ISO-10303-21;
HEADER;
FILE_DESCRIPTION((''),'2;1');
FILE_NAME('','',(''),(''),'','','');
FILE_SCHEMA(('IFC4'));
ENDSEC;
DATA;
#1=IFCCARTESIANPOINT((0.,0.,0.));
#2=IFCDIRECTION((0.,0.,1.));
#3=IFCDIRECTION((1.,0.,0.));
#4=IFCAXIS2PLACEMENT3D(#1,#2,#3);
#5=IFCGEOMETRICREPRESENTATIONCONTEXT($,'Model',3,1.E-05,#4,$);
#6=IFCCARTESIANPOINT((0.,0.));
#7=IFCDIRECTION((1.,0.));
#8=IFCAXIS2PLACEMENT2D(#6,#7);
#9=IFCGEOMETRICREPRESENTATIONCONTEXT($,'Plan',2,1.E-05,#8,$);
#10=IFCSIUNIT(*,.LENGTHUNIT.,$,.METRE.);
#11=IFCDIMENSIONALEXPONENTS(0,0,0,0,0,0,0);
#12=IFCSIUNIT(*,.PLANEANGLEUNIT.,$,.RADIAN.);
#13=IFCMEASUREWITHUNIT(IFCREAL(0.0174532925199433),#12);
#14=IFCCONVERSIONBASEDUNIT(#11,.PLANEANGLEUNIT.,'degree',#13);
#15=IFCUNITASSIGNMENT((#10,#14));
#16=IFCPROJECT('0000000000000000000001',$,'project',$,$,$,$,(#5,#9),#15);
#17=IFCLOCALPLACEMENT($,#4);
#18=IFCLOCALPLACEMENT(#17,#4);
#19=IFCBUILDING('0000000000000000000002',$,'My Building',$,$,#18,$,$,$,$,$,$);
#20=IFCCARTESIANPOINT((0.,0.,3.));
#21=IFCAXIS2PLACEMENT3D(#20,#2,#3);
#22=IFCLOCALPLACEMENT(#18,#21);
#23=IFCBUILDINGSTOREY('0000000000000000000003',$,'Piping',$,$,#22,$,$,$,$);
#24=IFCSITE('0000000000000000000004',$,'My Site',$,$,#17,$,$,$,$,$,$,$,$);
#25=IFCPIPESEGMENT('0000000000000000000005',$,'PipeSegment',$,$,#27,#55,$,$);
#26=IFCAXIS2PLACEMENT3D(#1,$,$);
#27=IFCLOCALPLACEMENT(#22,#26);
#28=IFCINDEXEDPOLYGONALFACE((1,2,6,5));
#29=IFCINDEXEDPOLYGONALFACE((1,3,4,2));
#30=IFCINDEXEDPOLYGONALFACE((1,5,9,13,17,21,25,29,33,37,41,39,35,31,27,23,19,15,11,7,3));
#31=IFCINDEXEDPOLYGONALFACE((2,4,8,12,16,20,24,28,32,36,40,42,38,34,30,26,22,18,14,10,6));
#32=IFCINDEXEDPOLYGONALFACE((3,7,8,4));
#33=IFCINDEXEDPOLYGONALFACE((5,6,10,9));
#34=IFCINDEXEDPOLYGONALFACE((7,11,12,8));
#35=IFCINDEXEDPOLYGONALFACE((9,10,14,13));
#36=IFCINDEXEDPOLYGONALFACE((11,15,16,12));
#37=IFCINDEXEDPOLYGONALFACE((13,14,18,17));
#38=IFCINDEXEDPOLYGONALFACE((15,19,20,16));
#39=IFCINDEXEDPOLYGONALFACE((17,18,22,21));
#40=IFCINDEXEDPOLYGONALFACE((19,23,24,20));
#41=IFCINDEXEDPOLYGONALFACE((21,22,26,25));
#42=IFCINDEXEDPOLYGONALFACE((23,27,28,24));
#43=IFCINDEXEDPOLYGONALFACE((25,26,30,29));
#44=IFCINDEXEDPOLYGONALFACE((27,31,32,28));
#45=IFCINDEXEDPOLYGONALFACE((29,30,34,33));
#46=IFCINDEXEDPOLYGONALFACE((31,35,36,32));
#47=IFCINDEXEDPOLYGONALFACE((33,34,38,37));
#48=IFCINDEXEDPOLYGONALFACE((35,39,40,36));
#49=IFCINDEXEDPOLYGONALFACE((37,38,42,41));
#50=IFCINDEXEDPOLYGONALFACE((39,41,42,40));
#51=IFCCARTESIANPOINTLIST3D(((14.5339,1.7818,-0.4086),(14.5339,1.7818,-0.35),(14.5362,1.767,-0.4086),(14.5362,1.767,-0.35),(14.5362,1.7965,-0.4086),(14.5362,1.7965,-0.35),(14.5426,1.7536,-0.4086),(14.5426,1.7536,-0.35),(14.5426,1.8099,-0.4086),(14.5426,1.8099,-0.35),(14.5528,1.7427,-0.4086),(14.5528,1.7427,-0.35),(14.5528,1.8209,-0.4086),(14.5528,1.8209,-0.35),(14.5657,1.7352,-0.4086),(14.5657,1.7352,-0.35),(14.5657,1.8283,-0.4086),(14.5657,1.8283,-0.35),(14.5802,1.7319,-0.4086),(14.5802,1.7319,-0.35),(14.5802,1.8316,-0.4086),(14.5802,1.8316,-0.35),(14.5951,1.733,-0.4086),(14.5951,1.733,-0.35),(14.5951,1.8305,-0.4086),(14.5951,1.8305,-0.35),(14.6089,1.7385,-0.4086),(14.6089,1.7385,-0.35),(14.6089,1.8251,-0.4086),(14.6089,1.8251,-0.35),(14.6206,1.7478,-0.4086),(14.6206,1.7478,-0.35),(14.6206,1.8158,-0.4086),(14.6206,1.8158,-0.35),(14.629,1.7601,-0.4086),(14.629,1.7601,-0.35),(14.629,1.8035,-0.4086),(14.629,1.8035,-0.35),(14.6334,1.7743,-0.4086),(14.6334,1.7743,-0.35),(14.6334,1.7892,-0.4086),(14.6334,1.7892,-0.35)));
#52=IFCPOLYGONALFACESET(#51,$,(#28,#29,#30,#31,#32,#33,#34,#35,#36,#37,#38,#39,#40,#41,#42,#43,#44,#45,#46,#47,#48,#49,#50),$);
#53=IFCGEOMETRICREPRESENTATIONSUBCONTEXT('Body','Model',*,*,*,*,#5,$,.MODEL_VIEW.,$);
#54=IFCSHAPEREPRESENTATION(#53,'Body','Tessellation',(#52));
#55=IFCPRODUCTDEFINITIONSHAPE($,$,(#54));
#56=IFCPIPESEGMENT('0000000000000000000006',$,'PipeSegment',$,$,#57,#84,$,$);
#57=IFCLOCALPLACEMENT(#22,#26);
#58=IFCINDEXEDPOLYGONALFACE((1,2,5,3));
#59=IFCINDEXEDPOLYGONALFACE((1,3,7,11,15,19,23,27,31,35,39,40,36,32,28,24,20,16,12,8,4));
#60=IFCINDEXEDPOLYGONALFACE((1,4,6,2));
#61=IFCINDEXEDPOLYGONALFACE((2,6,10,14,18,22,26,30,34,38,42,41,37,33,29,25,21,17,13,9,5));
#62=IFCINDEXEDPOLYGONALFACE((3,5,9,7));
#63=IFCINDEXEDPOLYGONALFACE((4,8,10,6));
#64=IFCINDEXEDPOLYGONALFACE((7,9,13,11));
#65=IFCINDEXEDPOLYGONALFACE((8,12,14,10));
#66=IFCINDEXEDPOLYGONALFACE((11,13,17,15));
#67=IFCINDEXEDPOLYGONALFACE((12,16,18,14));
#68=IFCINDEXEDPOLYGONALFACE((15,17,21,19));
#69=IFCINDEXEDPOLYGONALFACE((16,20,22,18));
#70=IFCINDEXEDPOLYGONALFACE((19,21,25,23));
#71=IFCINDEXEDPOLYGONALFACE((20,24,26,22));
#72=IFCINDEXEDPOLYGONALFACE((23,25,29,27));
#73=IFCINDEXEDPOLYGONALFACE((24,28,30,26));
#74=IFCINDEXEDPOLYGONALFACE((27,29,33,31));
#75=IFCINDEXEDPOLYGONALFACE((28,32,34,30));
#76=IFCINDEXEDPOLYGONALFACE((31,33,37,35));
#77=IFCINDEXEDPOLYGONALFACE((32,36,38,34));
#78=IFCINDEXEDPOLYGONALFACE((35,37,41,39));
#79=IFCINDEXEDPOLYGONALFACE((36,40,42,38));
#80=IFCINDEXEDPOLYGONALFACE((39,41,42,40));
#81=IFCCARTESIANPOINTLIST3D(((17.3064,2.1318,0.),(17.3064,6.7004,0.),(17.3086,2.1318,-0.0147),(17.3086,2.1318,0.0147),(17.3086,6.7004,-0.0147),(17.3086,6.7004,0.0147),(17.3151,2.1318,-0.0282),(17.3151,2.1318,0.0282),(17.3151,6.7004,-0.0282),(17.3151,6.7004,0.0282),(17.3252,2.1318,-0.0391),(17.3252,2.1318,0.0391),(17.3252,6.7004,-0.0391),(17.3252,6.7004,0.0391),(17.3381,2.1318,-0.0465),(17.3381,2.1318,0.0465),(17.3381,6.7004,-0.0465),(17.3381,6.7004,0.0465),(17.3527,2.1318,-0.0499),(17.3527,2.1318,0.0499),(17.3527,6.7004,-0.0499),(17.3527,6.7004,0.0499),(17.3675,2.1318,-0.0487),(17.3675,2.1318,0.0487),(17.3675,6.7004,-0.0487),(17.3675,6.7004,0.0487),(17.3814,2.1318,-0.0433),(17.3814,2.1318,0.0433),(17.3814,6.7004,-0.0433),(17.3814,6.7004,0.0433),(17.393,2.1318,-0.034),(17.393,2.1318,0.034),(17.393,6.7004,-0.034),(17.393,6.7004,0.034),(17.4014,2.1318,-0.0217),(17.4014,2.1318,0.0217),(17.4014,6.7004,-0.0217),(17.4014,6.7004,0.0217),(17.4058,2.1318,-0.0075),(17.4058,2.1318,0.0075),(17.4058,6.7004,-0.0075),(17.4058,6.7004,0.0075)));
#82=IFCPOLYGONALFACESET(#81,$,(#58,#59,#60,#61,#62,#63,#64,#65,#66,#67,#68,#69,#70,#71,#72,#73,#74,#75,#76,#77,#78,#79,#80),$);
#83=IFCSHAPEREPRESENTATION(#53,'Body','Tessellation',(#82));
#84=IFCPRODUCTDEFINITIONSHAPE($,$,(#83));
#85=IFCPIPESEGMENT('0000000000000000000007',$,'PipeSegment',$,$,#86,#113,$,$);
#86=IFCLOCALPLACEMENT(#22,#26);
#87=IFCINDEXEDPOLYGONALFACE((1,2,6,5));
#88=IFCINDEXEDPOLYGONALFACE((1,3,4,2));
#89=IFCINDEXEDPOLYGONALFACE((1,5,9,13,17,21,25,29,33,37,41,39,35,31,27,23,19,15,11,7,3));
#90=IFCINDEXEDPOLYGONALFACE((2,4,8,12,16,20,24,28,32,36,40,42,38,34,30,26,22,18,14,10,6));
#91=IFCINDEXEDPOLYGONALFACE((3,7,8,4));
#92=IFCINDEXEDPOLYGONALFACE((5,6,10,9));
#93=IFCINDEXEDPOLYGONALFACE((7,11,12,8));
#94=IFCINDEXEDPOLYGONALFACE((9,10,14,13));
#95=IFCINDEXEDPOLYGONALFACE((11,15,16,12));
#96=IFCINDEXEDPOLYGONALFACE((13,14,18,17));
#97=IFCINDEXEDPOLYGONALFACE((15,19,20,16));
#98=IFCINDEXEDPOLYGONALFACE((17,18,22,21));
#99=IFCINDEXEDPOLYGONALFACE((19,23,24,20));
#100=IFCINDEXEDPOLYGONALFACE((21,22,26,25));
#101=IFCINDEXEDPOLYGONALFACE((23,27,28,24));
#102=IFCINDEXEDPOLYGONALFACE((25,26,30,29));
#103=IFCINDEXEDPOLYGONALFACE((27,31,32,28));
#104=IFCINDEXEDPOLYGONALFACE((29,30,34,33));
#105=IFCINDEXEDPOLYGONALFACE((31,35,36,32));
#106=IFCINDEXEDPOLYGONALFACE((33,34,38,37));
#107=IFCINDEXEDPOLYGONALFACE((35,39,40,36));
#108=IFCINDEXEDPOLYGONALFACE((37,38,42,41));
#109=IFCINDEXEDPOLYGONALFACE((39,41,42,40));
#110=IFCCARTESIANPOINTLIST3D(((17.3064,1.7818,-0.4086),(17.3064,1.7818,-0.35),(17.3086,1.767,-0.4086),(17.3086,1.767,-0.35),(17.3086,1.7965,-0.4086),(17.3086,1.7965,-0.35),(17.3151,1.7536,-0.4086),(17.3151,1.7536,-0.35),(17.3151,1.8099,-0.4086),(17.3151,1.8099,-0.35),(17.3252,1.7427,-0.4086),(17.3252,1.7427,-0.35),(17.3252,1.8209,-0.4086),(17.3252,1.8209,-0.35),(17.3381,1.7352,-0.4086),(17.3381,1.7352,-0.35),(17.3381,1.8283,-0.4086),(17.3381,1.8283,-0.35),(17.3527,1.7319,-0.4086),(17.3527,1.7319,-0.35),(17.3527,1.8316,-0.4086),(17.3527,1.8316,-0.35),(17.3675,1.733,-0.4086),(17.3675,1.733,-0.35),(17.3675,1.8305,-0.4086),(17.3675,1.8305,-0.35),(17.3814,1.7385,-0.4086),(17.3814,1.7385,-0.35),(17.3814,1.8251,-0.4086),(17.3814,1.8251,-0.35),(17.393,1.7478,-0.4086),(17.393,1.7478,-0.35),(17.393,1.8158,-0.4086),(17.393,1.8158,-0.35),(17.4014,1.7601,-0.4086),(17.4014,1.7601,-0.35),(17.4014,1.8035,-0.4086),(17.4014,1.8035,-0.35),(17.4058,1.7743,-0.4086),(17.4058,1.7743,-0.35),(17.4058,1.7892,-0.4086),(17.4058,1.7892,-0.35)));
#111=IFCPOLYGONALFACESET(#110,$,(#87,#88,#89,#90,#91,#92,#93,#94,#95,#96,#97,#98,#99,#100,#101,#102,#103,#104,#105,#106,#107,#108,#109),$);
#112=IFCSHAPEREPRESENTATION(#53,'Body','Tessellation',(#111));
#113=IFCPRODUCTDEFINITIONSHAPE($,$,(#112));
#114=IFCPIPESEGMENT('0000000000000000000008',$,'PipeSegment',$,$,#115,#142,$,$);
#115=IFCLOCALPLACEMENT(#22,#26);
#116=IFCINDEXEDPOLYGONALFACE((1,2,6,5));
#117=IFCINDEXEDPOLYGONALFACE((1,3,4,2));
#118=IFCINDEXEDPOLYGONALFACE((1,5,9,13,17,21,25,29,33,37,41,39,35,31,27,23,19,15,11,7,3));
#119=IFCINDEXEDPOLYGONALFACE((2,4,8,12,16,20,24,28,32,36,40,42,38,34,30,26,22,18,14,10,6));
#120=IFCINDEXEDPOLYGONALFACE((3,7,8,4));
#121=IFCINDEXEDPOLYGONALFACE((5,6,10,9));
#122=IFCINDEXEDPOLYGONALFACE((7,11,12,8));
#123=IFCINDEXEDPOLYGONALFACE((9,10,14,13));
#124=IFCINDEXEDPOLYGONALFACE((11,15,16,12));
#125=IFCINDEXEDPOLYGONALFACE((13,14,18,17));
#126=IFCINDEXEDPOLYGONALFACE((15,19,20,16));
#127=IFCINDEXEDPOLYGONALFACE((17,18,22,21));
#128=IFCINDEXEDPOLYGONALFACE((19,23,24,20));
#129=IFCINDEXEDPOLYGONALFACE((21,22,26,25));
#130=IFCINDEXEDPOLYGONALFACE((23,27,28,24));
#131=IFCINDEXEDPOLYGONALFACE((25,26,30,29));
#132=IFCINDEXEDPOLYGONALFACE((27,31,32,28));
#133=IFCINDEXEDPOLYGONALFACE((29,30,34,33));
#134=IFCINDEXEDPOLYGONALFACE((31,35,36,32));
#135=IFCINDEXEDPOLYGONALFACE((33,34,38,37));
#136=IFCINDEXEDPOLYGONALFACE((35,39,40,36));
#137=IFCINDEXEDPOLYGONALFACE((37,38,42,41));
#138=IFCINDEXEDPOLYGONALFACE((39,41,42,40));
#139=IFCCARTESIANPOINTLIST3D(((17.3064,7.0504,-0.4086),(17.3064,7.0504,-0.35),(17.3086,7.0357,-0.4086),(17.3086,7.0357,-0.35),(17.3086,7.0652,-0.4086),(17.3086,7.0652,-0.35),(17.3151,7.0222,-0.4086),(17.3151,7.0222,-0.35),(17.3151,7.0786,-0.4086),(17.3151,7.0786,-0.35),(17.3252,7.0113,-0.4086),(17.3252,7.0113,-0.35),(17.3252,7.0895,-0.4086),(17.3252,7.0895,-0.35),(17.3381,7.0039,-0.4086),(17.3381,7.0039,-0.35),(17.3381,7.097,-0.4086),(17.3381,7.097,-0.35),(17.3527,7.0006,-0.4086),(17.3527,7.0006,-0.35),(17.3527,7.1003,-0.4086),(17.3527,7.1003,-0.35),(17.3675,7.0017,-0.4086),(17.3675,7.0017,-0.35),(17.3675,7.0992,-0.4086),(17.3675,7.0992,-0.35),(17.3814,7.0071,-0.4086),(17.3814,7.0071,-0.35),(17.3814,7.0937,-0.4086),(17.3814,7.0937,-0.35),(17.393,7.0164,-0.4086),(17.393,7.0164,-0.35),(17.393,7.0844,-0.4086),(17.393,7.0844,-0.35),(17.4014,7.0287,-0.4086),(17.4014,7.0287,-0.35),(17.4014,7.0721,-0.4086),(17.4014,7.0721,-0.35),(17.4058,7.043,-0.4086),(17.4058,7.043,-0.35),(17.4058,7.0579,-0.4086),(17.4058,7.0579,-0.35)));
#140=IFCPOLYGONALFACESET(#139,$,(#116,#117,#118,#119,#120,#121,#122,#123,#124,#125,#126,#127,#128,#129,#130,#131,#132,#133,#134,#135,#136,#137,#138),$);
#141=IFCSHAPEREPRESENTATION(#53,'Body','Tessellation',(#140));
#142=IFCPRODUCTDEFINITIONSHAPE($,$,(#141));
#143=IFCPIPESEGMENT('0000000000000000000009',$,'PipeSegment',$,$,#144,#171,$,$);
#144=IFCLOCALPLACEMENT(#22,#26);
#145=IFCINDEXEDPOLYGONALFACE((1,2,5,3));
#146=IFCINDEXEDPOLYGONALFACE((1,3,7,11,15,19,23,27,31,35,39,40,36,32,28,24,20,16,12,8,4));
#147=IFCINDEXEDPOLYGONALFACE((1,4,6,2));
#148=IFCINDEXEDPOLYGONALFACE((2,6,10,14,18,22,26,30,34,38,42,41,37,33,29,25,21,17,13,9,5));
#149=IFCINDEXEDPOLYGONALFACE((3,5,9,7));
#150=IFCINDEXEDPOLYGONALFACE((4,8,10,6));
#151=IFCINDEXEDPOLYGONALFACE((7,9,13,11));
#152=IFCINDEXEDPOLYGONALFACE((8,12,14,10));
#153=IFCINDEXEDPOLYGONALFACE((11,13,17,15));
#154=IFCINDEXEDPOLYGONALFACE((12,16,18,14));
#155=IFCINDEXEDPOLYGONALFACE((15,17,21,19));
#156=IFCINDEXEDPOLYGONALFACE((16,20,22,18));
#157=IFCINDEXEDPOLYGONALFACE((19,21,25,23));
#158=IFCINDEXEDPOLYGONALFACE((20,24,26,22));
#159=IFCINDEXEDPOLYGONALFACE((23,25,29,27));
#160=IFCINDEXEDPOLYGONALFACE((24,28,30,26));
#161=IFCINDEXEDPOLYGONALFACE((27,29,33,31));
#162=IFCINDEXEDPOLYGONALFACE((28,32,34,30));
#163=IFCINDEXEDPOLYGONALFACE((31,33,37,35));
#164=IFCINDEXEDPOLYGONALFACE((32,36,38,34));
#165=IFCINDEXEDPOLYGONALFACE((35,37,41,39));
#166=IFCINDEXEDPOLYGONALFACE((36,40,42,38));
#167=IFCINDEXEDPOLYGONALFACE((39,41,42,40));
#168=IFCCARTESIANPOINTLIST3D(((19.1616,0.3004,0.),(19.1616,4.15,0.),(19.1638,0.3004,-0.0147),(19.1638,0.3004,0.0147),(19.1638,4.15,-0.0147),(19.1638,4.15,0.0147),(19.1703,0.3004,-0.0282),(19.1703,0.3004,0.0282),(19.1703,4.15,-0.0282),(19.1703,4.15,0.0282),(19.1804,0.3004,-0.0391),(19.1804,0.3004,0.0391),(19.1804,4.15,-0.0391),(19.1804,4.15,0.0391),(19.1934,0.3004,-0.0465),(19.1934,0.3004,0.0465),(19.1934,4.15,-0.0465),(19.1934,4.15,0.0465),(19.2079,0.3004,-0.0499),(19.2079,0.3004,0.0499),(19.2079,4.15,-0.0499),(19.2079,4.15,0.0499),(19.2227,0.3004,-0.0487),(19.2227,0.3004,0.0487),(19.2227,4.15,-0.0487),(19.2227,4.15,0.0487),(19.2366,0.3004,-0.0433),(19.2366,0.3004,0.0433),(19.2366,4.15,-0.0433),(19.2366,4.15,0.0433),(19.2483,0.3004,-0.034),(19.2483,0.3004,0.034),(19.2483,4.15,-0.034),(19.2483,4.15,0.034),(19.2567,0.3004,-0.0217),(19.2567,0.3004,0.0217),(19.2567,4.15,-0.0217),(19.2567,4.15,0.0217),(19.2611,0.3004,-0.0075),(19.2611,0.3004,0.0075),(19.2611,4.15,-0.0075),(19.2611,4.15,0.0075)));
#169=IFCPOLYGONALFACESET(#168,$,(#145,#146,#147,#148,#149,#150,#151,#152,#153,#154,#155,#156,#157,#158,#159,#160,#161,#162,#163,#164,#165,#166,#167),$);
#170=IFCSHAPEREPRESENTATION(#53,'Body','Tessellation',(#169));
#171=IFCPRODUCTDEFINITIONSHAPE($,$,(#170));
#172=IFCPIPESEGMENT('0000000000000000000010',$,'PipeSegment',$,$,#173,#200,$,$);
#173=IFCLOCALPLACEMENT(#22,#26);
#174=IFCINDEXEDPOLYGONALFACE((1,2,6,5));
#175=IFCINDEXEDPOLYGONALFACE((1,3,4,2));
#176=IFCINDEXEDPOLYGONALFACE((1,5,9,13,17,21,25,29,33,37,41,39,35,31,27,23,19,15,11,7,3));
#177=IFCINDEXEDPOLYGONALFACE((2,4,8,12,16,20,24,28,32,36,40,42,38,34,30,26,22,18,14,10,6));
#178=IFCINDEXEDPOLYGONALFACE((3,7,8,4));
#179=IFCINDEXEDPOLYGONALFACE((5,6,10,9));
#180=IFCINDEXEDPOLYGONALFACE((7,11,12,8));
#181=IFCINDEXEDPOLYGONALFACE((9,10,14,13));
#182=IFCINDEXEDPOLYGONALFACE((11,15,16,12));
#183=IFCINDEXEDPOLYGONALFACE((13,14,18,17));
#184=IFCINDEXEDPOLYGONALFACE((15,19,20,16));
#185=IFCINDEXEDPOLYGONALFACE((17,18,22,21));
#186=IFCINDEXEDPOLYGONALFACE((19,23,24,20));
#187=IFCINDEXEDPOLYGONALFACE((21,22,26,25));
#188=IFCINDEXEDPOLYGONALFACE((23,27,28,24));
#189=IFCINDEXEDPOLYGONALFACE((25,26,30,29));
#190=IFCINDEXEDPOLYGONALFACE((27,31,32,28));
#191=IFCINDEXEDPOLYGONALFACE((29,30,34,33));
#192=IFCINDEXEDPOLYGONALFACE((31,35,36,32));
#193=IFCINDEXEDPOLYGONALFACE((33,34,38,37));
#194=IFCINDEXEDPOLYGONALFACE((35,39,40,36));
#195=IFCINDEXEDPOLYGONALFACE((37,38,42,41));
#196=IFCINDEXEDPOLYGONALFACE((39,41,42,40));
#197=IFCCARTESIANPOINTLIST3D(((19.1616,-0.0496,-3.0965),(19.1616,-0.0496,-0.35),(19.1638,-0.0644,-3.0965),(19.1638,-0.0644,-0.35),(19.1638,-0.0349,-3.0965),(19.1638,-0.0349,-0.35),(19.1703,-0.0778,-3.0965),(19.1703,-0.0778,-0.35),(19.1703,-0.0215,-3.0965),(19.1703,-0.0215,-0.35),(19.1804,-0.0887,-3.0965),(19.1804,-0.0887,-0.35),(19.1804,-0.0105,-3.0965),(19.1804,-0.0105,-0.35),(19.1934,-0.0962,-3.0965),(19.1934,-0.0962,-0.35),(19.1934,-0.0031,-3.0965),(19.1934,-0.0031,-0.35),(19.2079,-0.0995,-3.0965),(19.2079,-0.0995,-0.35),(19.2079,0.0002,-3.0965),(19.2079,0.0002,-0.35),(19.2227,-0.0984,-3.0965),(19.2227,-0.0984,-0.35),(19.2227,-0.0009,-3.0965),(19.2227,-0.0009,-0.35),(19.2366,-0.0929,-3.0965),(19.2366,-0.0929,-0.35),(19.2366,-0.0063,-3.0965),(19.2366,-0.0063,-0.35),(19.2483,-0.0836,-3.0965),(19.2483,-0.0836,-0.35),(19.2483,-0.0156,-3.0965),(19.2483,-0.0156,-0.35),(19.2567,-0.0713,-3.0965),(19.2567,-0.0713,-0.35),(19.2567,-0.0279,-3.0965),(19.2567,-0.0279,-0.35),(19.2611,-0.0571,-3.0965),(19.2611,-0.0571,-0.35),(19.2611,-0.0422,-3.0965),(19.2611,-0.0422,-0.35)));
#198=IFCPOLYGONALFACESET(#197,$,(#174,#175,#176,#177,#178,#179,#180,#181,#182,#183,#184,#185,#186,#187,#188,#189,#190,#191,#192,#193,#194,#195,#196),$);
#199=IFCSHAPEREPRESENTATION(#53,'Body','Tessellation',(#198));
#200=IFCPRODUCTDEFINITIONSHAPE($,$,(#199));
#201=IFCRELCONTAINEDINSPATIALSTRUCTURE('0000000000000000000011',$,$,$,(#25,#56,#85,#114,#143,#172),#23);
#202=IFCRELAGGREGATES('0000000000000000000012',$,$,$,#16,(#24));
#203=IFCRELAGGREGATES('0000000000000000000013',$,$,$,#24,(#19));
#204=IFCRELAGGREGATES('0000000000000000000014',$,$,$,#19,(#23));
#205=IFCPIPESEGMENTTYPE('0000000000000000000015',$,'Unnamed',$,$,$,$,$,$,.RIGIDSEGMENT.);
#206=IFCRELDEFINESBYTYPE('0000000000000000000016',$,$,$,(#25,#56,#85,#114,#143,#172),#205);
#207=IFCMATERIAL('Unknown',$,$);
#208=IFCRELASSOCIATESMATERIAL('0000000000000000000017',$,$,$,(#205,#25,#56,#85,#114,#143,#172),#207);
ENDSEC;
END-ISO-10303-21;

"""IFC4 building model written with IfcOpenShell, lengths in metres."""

from ifc_helpers import new_model, entity, si_unit, converted_unit, frame, origin_with_axes, origin_2d_with_axis, place, context, subcontext, project, spatial, circle, extrude, material, material_profile, profile_set, profile_usage, type_object, element, save


model = new_model("IFC4")

# Units and contexts
model_context = context("Model", 3, precision=1e-05, world=origin_with_axes())
plan_context = context("Plan", 2, precision=1e-05, world=origin_2d_with_axis())
body_context = subcontext(model_context, "Body", "Model", "MODEL_VIEW")
ifc_project = project(units=[si_unit("LENGTHUNIT", "METRE"), converted_unit("PLANEANGLEUNIT", "degree", entity("IfcReal", 0.0174532925199433), si_unit("PLANEANGLEUNIT", "RADIAN"), dimensions=[0, 0, 0, 0, 0, 0, 0])], contexts=[model_context, plan_context])

# Site, building, storey
site_placement = place(None, origin_with_axes())
site = spatial("IfcSite", under=ifc_project, at=site_placement, Name="My Site")
building_placement = place(site_placement, origin_with_axes())
building = spatial("IfcBuilding", under=site, at=building_placement, Name="My Building")
storey_placement = place(building_placement, frame((0.0, 0.0, 3.0), z_axis=(0.0, 0.0, 1.0), x_axis=(1.0, 0.0, 0.0)))
storey = spatial("IfcBuildingStorey", under=building, at=storey_placement, Name="Piping")

# Pipe segments
ifc_material = material(Name="Unknown")
ifc_material_profile = material_profile(ifc_material, circle(Radius=0.05))
ifc_profile_set = profile_set([ifc_material_profile])
pipe_segment_type = type_object("IfcPipeSegmentType", Name="Unnamed", PredefinedType="RIGIDSEGMENT", material=ifc_profile_set)
ifc_profile_usage_1 = profile_usage(ifc_profile_set, cardinal=5)
pipe_segment_1_placement = place(storey_placement, frame((14.5839, 1.7818, -0.35), z_axis=(0.0, 0.0, -1.0), x_axis=(-1.0, 0.0, 0.0)))
element("IfcPipeSegment", 1, at=pipe_segment_1_placement, inside=storey, type_object=pipe_segment_type, material=ifc_profile_usage_1, Name="PipeSegment", context=body_context, shape_type="SweptSolid", body=[
    extrude(circle(Radius=0.05), origin_with_axes(), (0.0, 0.0, 1.0), 0.0586),
])
ifc_profile_usage_2 = profile_usage(ifc_profile_set, cardinal=5)
pipe_segment_2_placement = place(storey_placement, frame((17.3564, 2.1318, 0.0), z_axis=(0.0, 1.0, 0.0), x_axis=(-1.0, 0.0, 0.0)))
element("IfcPipeSegment", 2, at=pipe_segment_2_placement, inside=storey, type_object=pipe_segment_type, material=ifc_profile_usage_2, Name="PipeSegment", context=body_context, shape_type="SweptSolid", body=[
    extrude(circle(Radius=0.05), origin_with_axes(), (0.0, 0.0, 1.0), 4.5686),
])
ifc_profile_usage_3 = profile_usage(ifc_profile_set, cardinal=5)
pipe_segment_3_placement = place(storey_placement, frame((17.3564, 1.7818, -0.35), z_axis=(0.0, 0.0, -1.0), x_axis=(-1.0, 0.0, 0.0)))
element("IfcPipeSegment", 3, at=pipe_segment_3_placement, inside=storey, type_object=pipe_segment_type, material=ifc_profile_usage_3, Name="PipeSegment", context=body_context, shape_type="SweptSolid", body=[
    extrude(circle(Radius=0.05), origin_with_axes(), (0.0, 0.0, 1.0), 0.0586),
])
ifc_profile_usage_4 = profile_usage(ifc_profile_set, cardinal=5)
pipe_segment_4_placement = place(storey_placement, frame((17.3564, 7.0504, -0.35), z_axis=(0.0, 0.0, -1.0), x_axis=(-1.0, 0.0, 0.0)))
element("IfcPipeSegment", 4, at=pipe_segment_4_placement, inside=storey, type_object=pipe_segment_type, material=ifc_profile_usage_4, Name="PipeSegment", context=body_context, shape_type="SweptSolid", body=[
    extrude(circle(Radius=0.05), origin_with_axes(), (0.0, 0.0, 1.0), 0.0586),
])
ifc_profile_usage_5 = profile_usage(ifc_profile_set, cardinal=5)
pipe_segment_5_placement = place(storey_placement, frame((19.2116, 0.3004, 0.0), z_axis=(0.0, 1.0, 0.0), x_axis=(-1.0, 0.0, 0.0)))
element("IfcPipeSegment", 5, at=pipe_segment_5_placement, inside=storey, type_object=pipe_segment_type, material=ifc_profile_usage_5, Name="PipeSegment", context=body_context, shape_type="SweptSolid", body=[
    extrude(circle(Radius=0.05), origin_with_axes(), (0.0, 0.0, 1.0), 3.8496),
])
ifc_profile_usage_6 = profile_usage(ifc_profile_set, cardinal=5)
pipe_segment_6_placement = place(storey_placement, frame((19.2116, -0.0496, -0.35), z_axis=(0.0, 0.0, -1.0), x_axis=(-1.0, 0.0, 0.0)))
element("IfcPipeSegment", 6, at=pipe_segment_6_placement, inside=storey, type_object=pipe_segment_type, material=ifc_profile_usage_6, Name="PipeSegment", context=body_context, shape_type="SweptSolid", body=[
    extrude(circle(Radius=0.05), origin_with_axes(), (0.0, 0.0, 1.0), 2.7465),
])

save(model, "model.ifc")
